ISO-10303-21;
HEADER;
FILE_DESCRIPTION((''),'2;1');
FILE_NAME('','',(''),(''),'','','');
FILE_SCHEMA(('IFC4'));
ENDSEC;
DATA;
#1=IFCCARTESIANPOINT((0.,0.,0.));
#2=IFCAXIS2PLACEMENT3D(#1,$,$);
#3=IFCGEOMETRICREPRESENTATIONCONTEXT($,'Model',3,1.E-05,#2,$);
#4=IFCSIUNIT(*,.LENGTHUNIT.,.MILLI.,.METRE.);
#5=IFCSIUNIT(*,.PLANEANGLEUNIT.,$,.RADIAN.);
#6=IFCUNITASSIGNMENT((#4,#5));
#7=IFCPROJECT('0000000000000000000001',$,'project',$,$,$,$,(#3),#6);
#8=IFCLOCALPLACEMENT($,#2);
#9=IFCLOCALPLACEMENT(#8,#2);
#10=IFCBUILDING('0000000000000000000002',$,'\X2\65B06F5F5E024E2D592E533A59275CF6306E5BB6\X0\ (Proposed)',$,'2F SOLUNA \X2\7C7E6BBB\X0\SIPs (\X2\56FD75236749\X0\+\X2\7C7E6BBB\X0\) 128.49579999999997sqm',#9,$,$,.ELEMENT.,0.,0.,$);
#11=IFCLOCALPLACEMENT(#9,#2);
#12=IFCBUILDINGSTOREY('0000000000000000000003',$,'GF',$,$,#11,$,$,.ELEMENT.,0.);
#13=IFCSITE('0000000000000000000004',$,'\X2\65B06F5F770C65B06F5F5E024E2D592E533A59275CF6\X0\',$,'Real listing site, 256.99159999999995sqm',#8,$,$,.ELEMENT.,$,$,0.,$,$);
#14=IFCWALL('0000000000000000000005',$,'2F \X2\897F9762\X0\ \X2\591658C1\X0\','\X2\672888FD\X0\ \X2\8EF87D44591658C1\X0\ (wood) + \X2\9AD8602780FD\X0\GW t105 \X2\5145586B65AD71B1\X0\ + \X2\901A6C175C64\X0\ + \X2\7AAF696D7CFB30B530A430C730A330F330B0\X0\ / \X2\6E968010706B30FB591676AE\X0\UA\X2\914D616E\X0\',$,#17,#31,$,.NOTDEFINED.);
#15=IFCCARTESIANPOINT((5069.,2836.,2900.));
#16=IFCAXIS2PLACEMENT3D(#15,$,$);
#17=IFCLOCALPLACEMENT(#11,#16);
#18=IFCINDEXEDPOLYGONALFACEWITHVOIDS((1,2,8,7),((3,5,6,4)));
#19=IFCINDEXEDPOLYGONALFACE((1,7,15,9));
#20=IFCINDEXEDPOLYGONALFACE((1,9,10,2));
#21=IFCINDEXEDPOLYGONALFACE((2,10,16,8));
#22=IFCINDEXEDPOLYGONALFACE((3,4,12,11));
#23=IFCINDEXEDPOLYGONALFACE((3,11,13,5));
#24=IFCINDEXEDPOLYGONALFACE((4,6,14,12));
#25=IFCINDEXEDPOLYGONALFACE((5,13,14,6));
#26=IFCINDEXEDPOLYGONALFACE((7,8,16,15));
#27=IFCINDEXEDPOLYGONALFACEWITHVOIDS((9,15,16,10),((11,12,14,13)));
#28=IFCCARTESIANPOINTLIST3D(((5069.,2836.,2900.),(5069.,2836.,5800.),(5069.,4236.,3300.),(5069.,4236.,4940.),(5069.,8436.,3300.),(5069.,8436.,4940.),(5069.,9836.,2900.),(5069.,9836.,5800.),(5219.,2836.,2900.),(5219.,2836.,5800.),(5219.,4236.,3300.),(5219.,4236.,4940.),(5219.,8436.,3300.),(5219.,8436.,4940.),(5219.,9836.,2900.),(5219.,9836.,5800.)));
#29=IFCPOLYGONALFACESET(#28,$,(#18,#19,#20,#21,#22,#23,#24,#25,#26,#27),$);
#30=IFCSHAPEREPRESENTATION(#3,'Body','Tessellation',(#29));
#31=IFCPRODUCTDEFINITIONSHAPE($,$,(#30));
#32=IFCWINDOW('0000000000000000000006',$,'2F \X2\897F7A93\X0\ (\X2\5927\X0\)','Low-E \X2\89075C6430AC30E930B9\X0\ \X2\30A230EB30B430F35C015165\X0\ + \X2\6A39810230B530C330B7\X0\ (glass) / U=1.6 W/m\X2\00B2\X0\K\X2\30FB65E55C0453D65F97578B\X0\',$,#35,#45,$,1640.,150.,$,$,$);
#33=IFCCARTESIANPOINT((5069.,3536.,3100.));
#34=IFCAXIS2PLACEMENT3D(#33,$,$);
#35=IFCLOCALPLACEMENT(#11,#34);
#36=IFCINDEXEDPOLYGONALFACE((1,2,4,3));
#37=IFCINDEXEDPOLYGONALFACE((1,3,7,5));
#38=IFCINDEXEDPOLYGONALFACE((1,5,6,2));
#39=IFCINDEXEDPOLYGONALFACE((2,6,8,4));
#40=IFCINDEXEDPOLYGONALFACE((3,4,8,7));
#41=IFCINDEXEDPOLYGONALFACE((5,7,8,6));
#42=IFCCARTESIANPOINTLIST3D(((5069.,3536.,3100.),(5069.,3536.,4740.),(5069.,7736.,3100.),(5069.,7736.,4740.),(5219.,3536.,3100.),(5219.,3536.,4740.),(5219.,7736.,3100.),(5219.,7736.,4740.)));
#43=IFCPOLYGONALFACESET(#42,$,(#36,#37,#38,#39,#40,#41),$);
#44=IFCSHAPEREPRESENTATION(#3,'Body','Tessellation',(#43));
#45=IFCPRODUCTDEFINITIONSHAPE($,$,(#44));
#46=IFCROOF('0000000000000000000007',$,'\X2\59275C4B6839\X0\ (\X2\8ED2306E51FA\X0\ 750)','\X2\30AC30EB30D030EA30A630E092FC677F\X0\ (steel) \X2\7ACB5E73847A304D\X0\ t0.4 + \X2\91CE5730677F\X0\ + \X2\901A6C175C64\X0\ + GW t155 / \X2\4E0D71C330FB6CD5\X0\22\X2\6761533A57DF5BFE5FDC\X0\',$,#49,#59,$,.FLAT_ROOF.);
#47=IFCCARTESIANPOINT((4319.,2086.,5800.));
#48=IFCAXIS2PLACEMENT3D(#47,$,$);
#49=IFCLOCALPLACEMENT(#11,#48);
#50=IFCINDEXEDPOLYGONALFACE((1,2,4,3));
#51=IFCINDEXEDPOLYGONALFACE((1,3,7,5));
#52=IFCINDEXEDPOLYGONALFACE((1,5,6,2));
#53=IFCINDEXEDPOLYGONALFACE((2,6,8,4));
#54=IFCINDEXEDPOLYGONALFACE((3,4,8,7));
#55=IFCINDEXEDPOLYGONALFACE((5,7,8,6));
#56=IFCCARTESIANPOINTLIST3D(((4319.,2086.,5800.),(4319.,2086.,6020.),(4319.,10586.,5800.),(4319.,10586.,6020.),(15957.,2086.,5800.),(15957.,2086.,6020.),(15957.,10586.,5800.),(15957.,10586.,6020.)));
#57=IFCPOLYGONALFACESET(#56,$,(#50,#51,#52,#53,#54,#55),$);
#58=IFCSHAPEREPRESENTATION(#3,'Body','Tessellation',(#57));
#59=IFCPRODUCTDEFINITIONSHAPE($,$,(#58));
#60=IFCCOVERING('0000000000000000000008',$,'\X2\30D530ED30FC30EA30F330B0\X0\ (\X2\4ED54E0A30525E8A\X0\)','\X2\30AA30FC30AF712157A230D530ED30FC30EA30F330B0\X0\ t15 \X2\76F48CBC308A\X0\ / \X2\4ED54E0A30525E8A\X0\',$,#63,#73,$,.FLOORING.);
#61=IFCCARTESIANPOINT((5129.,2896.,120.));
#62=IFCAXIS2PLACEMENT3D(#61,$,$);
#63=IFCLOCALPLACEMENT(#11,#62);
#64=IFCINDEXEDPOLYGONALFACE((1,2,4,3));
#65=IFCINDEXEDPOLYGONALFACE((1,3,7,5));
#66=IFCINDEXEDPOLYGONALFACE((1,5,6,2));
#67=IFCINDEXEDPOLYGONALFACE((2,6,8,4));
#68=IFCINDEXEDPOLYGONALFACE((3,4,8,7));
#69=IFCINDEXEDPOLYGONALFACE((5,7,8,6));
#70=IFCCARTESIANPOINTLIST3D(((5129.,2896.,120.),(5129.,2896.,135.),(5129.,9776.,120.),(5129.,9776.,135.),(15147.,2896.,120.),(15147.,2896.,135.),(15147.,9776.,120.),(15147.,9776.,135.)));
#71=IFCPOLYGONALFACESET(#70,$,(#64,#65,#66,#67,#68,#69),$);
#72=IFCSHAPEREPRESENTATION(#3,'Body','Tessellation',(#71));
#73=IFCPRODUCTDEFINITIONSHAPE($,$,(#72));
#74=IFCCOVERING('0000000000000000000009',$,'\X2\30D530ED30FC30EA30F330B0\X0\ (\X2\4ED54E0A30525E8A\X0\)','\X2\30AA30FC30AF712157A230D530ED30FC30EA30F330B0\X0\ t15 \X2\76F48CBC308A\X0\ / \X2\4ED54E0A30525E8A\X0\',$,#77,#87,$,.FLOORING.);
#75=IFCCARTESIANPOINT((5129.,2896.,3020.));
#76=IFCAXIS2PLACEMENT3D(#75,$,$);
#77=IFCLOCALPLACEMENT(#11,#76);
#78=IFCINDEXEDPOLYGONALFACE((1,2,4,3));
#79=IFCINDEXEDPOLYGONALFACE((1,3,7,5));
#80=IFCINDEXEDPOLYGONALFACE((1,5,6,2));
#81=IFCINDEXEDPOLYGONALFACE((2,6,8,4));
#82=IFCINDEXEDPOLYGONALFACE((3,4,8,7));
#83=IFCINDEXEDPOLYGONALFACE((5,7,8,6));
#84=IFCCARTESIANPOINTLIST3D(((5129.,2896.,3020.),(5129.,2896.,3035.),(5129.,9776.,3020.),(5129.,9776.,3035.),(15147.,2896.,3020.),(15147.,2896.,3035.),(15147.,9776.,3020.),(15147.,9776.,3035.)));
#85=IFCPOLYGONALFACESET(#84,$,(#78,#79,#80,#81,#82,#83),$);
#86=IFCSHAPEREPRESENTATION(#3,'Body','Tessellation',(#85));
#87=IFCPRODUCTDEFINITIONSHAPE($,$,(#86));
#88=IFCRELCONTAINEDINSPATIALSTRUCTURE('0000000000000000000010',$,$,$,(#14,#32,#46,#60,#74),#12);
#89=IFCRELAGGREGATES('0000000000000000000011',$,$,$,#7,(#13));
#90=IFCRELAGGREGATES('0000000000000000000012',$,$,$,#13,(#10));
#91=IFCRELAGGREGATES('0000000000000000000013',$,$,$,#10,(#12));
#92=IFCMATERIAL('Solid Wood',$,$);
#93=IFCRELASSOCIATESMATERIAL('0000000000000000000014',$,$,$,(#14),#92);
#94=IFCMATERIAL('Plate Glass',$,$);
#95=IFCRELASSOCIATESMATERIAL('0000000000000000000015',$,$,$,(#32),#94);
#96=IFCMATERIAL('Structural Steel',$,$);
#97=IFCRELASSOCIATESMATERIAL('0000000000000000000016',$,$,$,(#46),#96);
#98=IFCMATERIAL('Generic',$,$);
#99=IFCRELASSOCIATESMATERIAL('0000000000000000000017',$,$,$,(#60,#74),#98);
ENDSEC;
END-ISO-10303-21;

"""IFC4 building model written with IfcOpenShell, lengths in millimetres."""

from ifc_helpers import new_model, si_unit, frame, frame_2d, origin, place, context, project, spatial, rectangle, extrude, material, element, fill, save


model = new_model("IFC4")

# Units and contexts
model_context = context("Model", 3, precision=1e-05, world=origin())
ifc_project = project(units=[si_unit("LENGTHUNIT", "METRE", prefix="MILLI"), si_unit("PLANEANGLEUNIT", "RADIAN")], contexts=[model_context])

# Site, building, storey
site_placement = place(None, origin())
site = spatial("IfcSite", under=ifc_project, at=site_placement, Name="新潟県新潟市中央区大島", ObjectType="Real listing site, 256.99159999999995sqm", CompositionType="ELEMENT", RefElevation=0.0)
building_placement = place(site_placement, origin())
building = spatial("IfcBuilding", under=site, at=building_placement, Name="新潟市中央区大島の家 (Proposed)", ObjectType="2F SOLUNA 籾殻SIPs (国産杉+籾殻) 128.49579999999997sqm", CompositionType="ELEMENT", ElevationOfRefHeight=0.0, ElevationOfTerrain=0.0)
storey_placement = place(building_placement, origin())
storey = spatial("IfcBuildingStorey", under=building, at=storey_placement, Name="GF", CompositionType="ELEMENT", Elevation=0.0)

# Shared definitions
ifc_material_1 = material(Name="Solid Wood")

# Shared definitions
ifc_material_2 = material(Name="Plate Glass")

# Wall, opening, window
wall_1_placement = place(storey_placement, frame((5069.0, 2836.0, 2900.0)))
wall_1 = element("IfcWall", 1, at=wall_1_placement, inside=storey, material=ifc_material_1, Name="2F 西面 外壁", Description="木製 軸組外壁 (wood) + 高性能GW t105 充填断熱 + 通気層 + 窯業系サイディング / 準耐火・外皮UA配慮", PredefinedType="NOTDEFINED", context=model_context, shape_type="SweptSolid", body=[
    extrude(rectangle(XDim=150.0, YDim=7000.0, at=frame_2d((75.0, 3500.0))), frame((5069.0, 2836.0, 2900.0)), (0.0, 0.0, 1.0), 2900.0),
])
opening_1_placement = place(storey_placement, frame((5069.0, 3536.0, 3100.0)))
opening_1 = element("IfcOpeningElement", 2, at=opening_1_placement, cuts=wall_1, PredefinedType="NOTDEFINED", context=model_context, shape_type="SweptSolid", body=[
    extrude(rectangle(XDim=150.0, YDim=4200.0, at=frame_2d((75.0, 2100.0))), frame((5069.0, 3536.0, 3100.0)), (0.0, 0.0, 1.0), 1640.0),
])
window_1_placement = place(storey_placement, frame((5069.0, 3536.0, 3100.0)))
window_1 = element("IfcWindow", 3, at=window_1_placement, inside=storey, material=ifc_material_2, Name="2F 西窓 (大)", Description="Low-E 複層ガラス アルゴン封入 + 樹脂サッシ (glass) / U=1.6 W/m²K・日射取得型", OverallHeight=1640.0, OverallWidth=150.0, context=model_context, shape_type="SweptSolid", body=[
    extrude(rectangle(XDim=150.0, YDim=4200.0, at=frame_2d((75.0, 2100.0))), frame((5069.0, 3536.0, 3100.0)), (0.0, 0.0, 1.0), 1640.0),
])
fill(opening_1, window_1)

# Roof
ifc_material_3 = material(Name="Structural Steel")
roof_placement = place(storey_placement, frame((4319.0, 2086.0, 5800.0)))
element("IfcRoof", 4, at=roof_placement, inside=storey, material=ifc_material_3, Name="大屋根 (軒の出 750)", Description="ガルバリウム鋼板 (steel) 立平葺き t0.4 + 野地板 + 通気層 + GW t155 / 不燃・法22条区域対応", PredefinedType="FLAT_ROOF", context=model_context, shape_type="SweptSolid", body=[
    extrude(rectangle(XDim=11638.0, YDim=8500.0, at=frame_2d((5819.0, 4250.0))), frame((4319.0, 2086.0, 5800.0)), (0.0, 0.0, 1.0), 220.0),
])

# Coverings
ifc_material_4 = material(Name="Generic")
covering_1_placement = place(storey_placement, frame((5129.0, 2896.0, 120.0)))
element("IfcCovering", 5, at=covering_1_placement, inside=storey, material=ifc_material_4, Name="フローリング (仕上げ床)", Description="オーク無垢フローリング t15 直貼り / 仕上げ床", PredefinedType="FLOORING", context=model_context, shape_type="SweptSolid", body=[
    extrude(rectangle(XDim=10018.0, YDim=6880.0, at=frame_2d((5009.0, 3440.0))), frame((5129.0, 2896.0, 120.0)), (0.0, 0.0, 1.0), 15.0),
])
covering_2_placement = place(storey_placement, frame((5129.0, 2896.0, 3020.0)))
element("IfcCovering", 6, at=covering_2_placement, inside=storey, material=ifc_material_4, Name="フローリング (仕上げ床)", Description="オーク無垢フローリング t15 直貼り / 仕上げ床", PredefinedType="FLOORING", context=model_context, shape_type="SweptSolid", body=[
    extrude(rectangle(XDim=10018.0, YDim=6880.0, at=frame_2d((5009.0, 3440.0))), frame((5129.0, 2896.0, 3020.0)), (0.0, 0.0, 1.0), 15.0),
])

save(model, "model.ifc")
